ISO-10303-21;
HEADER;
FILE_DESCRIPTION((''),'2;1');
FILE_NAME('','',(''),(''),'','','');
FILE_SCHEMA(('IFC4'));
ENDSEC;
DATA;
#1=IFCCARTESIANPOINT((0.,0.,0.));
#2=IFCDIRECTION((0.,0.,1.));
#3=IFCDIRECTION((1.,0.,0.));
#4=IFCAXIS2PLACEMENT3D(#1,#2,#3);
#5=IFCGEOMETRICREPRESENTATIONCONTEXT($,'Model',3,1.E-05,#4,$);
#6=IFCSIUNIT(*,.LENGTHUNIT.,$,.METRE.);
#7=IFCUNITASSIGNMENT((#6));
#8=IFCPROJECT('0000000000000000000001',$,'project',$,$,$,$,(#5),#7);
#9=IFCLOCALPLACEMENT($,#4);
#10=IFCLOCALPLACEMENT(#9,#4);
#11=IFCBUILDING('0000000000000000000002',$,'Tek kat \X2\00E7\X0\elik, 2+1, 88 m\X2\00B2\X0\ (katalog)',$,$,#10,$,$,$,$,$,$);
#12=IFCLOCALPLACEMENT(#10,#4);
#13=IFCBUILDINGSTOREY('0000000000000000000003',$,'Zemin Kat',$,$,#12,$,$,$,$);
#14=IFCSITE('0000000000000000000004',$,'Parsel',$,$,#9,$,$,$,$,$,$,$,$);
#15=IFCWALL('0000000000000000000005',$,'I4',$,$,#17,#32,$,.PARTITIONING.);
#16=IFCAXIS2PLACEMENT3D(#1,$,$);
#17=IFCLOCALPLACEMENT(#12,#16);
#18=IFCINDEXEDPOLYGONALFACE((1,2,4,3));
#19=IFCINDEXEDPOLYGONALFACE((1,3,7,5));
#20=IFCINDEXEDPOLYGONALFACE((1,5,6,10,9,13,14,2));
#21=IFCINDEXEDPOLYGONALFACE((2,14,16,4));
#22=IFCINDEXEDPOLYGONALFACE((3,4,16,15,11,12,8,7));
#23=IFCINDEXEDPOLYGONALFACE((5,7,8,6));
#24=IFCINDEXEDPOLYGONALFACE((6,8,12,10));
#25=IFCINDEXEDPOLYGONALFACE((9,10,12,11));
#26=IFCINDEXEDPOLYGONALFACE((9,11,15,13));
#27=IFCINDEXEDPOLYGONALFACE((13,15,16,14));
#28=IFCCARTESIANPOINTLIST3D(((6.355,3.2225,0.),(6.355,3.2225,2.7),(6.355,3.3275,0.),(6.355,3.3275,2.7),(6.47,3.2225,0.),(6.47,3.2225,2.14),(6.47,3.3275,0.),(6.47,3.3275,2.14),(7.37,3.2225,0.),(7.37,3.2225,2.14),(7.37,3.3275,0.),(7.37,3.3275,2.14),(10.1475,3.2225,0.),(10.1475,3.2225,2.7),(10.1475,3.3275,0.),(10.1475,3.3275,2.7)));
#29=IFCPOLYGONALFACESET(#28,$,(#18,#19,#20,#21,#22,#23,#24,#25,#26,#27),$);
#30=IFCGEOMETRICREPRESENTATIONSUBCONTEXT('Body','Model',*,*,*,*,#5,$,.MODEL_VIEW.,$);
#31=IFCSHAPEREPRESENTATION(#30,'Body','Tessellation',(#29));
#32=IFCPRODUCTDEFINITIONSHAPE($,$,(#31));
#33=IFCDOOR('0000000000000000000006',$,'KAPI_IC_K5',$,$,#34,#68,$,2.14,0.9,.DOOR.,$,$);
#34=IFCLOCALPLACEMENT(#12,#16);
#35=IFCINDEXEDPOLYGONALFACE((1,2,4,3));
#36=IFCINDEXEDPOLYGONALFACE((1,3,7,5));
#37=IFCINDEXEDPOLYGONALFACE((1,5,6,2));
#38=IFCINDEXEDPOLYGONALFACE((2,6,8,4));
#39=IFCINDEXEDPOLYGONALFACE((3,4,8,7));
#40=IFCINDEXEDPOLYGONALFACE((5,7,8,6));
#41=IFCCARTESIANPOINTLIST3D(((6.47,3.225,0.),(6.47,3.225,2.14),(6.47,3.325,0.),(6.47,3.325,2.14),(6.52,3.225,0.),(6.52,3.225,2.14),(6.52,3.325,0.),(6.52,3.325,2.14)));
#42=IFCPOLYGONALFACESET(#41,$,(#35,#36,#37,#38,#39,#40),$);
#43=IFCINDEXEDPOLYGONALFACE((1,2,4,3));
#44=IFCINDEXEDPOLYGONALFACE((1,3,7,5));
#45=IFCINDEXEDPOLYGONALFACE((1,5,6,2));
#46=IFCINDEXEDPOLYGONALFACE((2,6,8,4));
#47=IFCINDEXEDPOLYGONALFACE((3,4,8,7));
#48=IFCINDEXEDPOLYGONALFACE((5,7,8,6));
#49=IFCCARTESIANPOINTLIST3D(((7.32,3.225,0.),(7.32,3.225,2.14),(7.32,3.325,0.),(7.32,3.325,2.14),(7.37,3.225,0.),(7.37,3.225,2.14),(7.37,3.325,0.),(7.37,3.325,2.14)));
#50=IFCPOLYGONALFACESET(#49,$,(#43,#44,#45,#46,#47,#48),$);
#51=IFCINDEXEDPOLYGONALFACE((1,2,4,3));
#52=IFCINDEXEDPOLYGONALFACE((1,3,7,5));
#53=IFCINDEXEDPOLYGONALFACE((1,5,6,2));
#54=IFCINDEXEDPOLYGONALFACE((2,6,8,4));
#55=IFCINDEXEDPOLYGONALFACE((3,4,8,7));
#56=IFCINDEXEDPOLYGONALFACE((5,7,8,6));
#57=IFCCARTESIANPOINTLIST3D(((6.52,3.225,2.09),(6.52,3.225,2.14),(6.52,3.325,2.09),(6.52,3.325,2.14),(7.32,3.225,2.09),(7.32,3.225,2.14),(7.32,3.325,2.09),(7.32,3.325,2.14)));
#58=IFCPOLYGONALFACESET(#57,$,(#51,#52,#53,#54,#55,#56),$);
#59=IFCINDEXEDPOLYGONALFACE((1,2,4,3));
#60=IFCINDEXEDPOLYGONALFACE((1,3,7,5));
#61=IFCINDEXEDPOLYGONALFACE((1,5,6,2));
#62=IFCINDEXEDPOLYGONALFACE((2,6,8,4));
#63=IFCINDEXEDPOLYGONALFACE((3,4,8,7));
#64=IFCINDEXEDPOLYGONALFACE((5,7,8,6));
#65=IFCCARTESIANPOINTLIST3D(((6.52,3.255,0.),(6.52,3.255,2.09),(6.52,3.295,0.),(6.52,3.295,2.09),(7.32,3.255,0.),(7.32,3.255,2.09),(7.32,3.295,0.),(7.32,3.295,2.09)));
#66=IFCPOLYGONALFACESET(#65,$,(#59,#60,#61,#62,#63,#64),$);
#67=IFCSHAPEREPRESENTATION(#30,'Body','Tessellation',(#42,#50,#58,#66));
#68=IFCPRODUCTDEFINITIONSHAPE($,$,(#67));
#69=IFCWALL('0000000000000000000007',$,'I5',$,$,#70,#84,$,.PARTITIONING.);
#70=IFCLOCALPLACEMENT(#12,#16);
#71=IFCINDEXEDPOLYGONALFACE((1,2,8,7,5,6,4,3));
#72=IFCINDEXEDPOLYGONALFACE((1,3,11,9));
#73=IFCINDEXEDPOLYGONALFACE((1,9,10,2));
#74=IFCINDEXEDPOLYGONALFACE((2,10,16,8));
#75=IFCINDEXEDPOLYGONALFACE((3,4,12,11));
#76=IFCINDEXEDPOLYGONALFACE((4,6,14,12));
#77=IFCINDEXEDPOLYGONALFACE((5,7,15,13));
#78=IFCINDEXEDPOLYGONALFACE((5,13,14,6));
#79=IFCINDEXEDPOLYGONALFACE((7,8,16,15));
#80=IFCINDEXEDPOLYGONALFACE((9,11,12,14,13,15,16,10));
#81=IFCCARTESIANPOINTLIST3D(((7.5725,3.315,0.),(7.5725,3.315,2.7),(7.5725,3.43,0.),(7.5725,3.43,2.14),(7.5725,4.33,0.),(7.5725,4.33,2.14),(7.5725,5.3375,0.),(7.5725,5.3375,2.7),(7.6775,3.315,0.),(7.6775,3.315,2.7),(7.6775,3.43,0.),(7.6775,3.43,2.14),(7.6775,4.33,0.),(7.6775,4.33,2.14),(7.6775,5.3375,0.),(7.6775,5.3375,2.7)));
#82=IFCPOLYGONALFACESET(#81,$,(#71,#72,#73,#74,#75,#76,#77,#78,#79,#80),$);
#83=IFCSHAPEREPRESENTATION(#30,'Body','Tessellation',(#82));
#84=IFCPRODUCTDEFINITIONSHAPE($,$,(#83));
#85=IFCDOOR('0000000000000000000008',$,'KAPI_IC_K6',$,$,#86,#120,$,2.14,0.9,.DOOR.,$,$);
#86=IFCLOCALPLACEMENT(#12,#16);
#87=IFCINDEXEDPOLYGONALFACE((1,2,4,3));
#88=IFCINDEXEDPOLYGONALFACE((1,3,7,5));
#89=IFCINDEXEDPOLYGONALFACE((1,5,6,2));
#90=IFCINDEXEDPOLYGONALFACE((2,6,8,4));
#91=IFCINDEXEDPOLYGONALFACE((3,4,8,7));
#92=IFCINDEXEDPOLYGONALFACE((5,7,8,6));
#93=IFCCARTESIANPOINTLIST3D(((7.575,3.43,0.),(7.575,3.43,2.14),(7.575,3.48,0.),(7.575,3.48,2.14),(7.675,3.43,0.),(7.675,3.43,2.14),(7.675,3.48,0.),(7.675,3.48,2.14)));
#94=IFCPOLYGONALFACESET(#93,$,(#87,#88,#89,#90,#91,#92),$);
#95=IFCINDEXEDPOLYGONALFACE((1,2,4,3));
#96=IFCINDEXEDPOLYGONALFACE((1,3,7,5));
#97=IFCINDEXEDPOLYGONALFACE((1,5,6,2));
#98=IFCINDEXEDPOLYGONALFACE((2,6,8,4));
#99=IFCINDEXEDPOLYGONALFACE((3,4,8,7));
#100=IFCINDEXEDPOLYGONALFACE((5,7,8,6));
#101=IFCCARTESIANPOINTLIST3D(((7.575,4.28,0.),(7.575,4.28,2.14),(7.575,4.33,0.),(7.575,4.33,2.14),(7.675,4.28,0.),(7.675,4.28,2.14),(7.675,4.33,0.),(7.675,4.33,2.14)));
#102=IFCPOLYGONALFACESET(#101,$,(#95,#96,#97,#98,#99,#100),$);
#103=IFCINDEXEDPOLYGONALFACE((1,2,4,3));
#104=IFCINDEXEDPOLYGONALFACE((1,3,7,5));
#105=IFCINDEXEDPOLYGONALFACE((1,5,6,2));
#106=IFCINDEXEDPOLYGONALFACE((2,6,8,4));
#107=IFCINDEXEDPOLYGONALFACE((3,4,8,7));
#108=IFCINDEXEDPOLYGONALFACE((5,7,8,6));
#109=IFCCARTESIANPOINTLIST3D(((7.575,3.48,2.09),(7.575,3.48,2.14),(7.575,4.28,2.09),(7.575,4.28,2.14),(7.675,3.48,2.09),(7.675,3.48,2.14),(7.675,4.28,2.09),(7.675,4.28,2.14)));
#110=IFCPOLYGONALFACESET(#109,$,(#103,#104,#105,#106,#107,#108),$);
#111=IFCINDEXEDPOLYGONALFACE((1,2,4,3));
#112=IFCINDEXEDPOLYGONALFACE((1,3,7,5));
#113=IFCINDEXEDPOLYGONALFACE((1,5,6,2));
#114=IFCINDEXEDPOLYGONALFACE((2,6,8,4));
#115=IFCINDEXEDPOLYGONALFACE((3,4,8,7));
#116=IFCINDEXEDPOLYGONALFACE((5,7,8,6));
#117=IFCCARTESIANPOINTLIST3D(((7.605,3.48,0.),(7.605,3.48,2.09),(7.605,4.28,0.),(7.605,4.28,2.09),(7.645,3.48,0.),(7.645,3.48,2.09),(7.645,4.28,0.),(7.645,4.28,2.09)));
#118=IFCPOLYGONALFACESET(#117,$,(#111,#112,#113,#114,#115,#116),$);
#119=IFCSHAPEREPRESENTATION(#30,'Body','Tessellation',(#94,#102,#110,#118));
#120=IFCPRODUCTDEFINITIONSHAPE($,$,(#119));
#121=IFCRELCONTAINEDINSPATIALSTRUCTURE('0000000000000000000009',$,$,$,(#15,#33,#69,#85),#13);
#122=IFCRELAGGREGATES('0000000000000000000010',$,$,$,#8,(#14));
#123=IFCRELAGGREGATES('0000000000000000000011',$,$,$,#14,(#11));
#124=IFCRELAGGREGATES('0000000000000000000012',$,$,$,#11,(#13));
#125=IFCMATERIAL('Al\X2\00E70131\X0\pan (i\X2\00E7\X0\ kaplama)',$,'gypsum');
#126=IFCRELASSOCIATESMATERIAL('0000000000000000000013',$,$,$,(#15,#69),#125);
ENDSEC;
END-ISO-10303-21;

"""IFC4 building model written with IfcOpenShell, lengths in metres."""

from ifc_helpers import new_model, si_unit, frame, origin_with_axes, place, context, subcontext, project, spatial, line, indexed_curve, outline, extrude, material, element, fill, save


model = new_model("IFC4")

# Units and contexts
model_context = context("Model", 3, precision=1e-05, world=origin_with_axes())
body_context = subcontext(model_context, "Body", "Model", "MODEL_VIEW")
ifc_project = project(units=[si_unit("LENGTHUNIT", "METRE")], contexts=[model_context])

# Site, building, storey
site_placement = place(None, origin_with_axes())
site = spatial("IfcSite", under=ifc_project, at=site_placement, Name="Parsel")
building_placement = place(site_placement, origin_with_axes())
building = spatial("IfcBuilding", under=site, at=building_placement, Name="Tek kat çelik, 2+1, 88 m² (katalog)")
storey_placement = place(building_placement, origin_with_axes())
storey = spatial("IfcBuildingStorey", under=building, at=storey_placement, Name="Zemin Kat")

# Shared definitions
ifc_material_1 = material(Name="Alçıpan (iç kaplama)", Category="gypsum")

# Walls, openings, doors
wall_1_placement = place(storey_placement, origin_with_axes())
wall_1 = element("IfcWall", 1, at=wall_1_placement, inside=storey, material=ifc_material_1, Name="I4", PredefinedType="PARTITIONING", context=body_context, shape_type="SweptSolid", body=[
    extrude(outline(indexed_curve([(0.0, 0.0), (3.7925, 0.0), (3.7925, 0.105), (0.0, 0.105)], segments=[line(1, 2, 3, 4, 1)])), frame((6.355, 3.2225, 0.0), z_axis=(0.0, 0.0, 1.0), x_axis=(1.0, 0.0, 0.0)), (0.0, 0.0, 1.0), 2.7),
])
opening_1_placement = place(wall_1_placement, origin_with_axes())
opening_1 = element("IfcOpeningElement", 2, at=opening_1_placement, cuts=wall_1, PredefinedType="OPENING", context=body_context, shape_type="SweptSolid", body=[
    extrude(outline(indexed_curve([(0.0, 0.0), (0.9, 0.0), (0.9, 0.145), (0.0, 0.145)], segments=[line(1, 2, 3, 4, 1)])), frame((6.47, 3.2025, 0.0), z_axis=(0.0, 0.0, 1.0), x_axis=(1.0, 0.0, 0.0)), (0.0, 0.0, 1.0), 2.14),
])
door_1_placement = place(storey_placement, origin_with_axes())
door_1 = element("IfcDoor", 3, at=door_1_placement, inside=storey, Name="KAPI_IC_K5", OverallHeight=2.14, OverallWidth=0.9, PredefinedType="DOOR", context=body_context, shape_type="SweptSolid", body=[
    extrude(outline(indexed_curve([(0.0, 0.0), (0.05, 0.0), (0.05, 0.1), (0.0, 0.1)], segments=[line(1, 2, 3, 4, 1)])), frame((6.47, 3.225, 0.0), z_axis=(0.0, 0.0, 1.0), x_axis=(1.0, 0.0, 0.0)), (0.0, 0.0, 1.0), 2.14),
    extrude(outline(indexed_curve([(0.0, 0.0), (0.05, 0.0), (0.05, 0.1), (0.0, 0.1)], segments=[line(1, 2, 3, 4, 1)])), frame((7.32, 3.225, 0.0), z_axis=(0.0, 0.0, 1.0), x_axis=(1.0, 0.0, 0.0)), (0.0, 0.0, 1.0), 2.14),
    extrude(outline(indexed_curve([(0.0, 0.0), (0.8, 0.0), (0.8, 0.1), (0.0, 0.1)], segments=[line(1, 2, 3, 4, 1)])), frame((6.52, 3.225, 2.09), z_axis=(0.0, 0.0, 1.0), x_axis=(1.0, 0.0, 0.0)), (0.0, 0.0, 1.0), 0.05),
    extrude(outline(indexed_curve([(0.0, 0.0), (0.8, 0.0), (0.8, 0.04), (0.0, 0.04)], segments=[line(1, 2, 3, 4, 1)])), frame((6.52, 3.255, 0.0), z_axis=(0.0, 0.0, 1.0), x_axis=(1.0, 0.0, 0.0)), (0.0, 0.0, 1.0), 2.09),
])
fill(opening_1, door_1)
wall_2_placement = place(storey_placement, origin_with_axes())
wall_2 = element("IfcWall", 4, at=wall_2_placement, inside=storey, material=ifc_material_1, Name="I5", PredefinedType="PARTITIONING", context=body_context, shape_type="SweptSolid", body=[
    extrude(outline(indexed_curve([(0.0, 0.0), (0.105, 0.0), (0.105, 2.0225), (0.0, 2.0225)], segments=[line(1, 2, 3, 4, 1)])), frame((7.5725, 3.315, 0.0), z_axis=(0.0, 0.0, 1.0), x_axis=(1.0, 0.0, 0.0)), (0.0, 0.0, 1.0), 2.7),
])
opening_2_placement = place(wall_2_placement, origin_with_axes())
opening_2 = element("IfcOpeningElement", 5, at=opening_2_placement, cuts=wall_2, PredefinedType="OPENING", context=body_context, shape_type="SweptSolid", body=[
    extrude(outline(indexed_curve([(0.0, 0.0), (0.145, 0.0), (0.145, 0.9), (0.0, 0.9)], segments=[line(1, 2, 3, 4, 1)])), frame((7.5525, 3.43, 0.0), z_axis=(0.0, 0.0, 1.0), x_axis=(1.0, 0.0, 0.0)), (0.0, 0.0, 1.0), 2.14),
])
door_2_placement = place(storey_placement, origin_with_axes())
door_2 = element("IfcDoor", 6, at=door_2_placement, inside=storey, Name="KAPI_IC_K6", OverallHeight=2.14, OverallWidth=0.9, PredefinedType="DOOR", context=body_context, shape_type="SweptSolid", body=[
    extrude(outline(indexed_curve([(0.0, 0.0), (0.1, 0.0), (0.1, 0.05), (0.0, 0.05)], segments=[line(1, 2, 3, 4, 1)])), frame((7.575, 3.43, 0.0), z_axis=(0.0, 0.0, 1.0), x_axis=(1.0, 0.0, 0.0)), (0.0, 0.0, 1.0), 2.14),
    extrude(outline(indexed_curve([(0.0, 0.0), (0.1, 0.0), (0.1, 0.05), (0.0, 0.05)], segments=[line(1, 2, 3, 4, 1)])), frame((7.575, 4.28, 0.0), z_axis=(0.0, 0.0, 1.0), x_axis=(1.0, 0.0, 0.0)), (0.0, 0.0, 1.0), 2.14),
    extrude(outline(indexed_curve([(0.0, 0.0), (0.1, 0.0), (0.1, 0.8), (0.0, 0.8)], segments=[line(1, 2, 3, 4, 1)])), frame((7.575, 3.48, 2.09), z_axis=(0.0, 0.0, 1.0), x_axis=(1.0, 0.0, 0.0)), (0.0, 0.0, 1.0), 0.05),
    extrude(outline(indexed_curve([(0.0, 0.0), (0.04, 0.0), (0.04, 0.8), (0.0, 0.8)], segments=[line(1, 2, 3, 4, 1)])), frame((7.605, 3.48, 0.0), z_axis=(0.0, 0.0, 1.0), x_axis=(1.0, 0.0, 0.0)), (0.0, 0.0, 1.0), 2.09),
])
fill(opening_2, door_2)

save(model, "model.ifc")
